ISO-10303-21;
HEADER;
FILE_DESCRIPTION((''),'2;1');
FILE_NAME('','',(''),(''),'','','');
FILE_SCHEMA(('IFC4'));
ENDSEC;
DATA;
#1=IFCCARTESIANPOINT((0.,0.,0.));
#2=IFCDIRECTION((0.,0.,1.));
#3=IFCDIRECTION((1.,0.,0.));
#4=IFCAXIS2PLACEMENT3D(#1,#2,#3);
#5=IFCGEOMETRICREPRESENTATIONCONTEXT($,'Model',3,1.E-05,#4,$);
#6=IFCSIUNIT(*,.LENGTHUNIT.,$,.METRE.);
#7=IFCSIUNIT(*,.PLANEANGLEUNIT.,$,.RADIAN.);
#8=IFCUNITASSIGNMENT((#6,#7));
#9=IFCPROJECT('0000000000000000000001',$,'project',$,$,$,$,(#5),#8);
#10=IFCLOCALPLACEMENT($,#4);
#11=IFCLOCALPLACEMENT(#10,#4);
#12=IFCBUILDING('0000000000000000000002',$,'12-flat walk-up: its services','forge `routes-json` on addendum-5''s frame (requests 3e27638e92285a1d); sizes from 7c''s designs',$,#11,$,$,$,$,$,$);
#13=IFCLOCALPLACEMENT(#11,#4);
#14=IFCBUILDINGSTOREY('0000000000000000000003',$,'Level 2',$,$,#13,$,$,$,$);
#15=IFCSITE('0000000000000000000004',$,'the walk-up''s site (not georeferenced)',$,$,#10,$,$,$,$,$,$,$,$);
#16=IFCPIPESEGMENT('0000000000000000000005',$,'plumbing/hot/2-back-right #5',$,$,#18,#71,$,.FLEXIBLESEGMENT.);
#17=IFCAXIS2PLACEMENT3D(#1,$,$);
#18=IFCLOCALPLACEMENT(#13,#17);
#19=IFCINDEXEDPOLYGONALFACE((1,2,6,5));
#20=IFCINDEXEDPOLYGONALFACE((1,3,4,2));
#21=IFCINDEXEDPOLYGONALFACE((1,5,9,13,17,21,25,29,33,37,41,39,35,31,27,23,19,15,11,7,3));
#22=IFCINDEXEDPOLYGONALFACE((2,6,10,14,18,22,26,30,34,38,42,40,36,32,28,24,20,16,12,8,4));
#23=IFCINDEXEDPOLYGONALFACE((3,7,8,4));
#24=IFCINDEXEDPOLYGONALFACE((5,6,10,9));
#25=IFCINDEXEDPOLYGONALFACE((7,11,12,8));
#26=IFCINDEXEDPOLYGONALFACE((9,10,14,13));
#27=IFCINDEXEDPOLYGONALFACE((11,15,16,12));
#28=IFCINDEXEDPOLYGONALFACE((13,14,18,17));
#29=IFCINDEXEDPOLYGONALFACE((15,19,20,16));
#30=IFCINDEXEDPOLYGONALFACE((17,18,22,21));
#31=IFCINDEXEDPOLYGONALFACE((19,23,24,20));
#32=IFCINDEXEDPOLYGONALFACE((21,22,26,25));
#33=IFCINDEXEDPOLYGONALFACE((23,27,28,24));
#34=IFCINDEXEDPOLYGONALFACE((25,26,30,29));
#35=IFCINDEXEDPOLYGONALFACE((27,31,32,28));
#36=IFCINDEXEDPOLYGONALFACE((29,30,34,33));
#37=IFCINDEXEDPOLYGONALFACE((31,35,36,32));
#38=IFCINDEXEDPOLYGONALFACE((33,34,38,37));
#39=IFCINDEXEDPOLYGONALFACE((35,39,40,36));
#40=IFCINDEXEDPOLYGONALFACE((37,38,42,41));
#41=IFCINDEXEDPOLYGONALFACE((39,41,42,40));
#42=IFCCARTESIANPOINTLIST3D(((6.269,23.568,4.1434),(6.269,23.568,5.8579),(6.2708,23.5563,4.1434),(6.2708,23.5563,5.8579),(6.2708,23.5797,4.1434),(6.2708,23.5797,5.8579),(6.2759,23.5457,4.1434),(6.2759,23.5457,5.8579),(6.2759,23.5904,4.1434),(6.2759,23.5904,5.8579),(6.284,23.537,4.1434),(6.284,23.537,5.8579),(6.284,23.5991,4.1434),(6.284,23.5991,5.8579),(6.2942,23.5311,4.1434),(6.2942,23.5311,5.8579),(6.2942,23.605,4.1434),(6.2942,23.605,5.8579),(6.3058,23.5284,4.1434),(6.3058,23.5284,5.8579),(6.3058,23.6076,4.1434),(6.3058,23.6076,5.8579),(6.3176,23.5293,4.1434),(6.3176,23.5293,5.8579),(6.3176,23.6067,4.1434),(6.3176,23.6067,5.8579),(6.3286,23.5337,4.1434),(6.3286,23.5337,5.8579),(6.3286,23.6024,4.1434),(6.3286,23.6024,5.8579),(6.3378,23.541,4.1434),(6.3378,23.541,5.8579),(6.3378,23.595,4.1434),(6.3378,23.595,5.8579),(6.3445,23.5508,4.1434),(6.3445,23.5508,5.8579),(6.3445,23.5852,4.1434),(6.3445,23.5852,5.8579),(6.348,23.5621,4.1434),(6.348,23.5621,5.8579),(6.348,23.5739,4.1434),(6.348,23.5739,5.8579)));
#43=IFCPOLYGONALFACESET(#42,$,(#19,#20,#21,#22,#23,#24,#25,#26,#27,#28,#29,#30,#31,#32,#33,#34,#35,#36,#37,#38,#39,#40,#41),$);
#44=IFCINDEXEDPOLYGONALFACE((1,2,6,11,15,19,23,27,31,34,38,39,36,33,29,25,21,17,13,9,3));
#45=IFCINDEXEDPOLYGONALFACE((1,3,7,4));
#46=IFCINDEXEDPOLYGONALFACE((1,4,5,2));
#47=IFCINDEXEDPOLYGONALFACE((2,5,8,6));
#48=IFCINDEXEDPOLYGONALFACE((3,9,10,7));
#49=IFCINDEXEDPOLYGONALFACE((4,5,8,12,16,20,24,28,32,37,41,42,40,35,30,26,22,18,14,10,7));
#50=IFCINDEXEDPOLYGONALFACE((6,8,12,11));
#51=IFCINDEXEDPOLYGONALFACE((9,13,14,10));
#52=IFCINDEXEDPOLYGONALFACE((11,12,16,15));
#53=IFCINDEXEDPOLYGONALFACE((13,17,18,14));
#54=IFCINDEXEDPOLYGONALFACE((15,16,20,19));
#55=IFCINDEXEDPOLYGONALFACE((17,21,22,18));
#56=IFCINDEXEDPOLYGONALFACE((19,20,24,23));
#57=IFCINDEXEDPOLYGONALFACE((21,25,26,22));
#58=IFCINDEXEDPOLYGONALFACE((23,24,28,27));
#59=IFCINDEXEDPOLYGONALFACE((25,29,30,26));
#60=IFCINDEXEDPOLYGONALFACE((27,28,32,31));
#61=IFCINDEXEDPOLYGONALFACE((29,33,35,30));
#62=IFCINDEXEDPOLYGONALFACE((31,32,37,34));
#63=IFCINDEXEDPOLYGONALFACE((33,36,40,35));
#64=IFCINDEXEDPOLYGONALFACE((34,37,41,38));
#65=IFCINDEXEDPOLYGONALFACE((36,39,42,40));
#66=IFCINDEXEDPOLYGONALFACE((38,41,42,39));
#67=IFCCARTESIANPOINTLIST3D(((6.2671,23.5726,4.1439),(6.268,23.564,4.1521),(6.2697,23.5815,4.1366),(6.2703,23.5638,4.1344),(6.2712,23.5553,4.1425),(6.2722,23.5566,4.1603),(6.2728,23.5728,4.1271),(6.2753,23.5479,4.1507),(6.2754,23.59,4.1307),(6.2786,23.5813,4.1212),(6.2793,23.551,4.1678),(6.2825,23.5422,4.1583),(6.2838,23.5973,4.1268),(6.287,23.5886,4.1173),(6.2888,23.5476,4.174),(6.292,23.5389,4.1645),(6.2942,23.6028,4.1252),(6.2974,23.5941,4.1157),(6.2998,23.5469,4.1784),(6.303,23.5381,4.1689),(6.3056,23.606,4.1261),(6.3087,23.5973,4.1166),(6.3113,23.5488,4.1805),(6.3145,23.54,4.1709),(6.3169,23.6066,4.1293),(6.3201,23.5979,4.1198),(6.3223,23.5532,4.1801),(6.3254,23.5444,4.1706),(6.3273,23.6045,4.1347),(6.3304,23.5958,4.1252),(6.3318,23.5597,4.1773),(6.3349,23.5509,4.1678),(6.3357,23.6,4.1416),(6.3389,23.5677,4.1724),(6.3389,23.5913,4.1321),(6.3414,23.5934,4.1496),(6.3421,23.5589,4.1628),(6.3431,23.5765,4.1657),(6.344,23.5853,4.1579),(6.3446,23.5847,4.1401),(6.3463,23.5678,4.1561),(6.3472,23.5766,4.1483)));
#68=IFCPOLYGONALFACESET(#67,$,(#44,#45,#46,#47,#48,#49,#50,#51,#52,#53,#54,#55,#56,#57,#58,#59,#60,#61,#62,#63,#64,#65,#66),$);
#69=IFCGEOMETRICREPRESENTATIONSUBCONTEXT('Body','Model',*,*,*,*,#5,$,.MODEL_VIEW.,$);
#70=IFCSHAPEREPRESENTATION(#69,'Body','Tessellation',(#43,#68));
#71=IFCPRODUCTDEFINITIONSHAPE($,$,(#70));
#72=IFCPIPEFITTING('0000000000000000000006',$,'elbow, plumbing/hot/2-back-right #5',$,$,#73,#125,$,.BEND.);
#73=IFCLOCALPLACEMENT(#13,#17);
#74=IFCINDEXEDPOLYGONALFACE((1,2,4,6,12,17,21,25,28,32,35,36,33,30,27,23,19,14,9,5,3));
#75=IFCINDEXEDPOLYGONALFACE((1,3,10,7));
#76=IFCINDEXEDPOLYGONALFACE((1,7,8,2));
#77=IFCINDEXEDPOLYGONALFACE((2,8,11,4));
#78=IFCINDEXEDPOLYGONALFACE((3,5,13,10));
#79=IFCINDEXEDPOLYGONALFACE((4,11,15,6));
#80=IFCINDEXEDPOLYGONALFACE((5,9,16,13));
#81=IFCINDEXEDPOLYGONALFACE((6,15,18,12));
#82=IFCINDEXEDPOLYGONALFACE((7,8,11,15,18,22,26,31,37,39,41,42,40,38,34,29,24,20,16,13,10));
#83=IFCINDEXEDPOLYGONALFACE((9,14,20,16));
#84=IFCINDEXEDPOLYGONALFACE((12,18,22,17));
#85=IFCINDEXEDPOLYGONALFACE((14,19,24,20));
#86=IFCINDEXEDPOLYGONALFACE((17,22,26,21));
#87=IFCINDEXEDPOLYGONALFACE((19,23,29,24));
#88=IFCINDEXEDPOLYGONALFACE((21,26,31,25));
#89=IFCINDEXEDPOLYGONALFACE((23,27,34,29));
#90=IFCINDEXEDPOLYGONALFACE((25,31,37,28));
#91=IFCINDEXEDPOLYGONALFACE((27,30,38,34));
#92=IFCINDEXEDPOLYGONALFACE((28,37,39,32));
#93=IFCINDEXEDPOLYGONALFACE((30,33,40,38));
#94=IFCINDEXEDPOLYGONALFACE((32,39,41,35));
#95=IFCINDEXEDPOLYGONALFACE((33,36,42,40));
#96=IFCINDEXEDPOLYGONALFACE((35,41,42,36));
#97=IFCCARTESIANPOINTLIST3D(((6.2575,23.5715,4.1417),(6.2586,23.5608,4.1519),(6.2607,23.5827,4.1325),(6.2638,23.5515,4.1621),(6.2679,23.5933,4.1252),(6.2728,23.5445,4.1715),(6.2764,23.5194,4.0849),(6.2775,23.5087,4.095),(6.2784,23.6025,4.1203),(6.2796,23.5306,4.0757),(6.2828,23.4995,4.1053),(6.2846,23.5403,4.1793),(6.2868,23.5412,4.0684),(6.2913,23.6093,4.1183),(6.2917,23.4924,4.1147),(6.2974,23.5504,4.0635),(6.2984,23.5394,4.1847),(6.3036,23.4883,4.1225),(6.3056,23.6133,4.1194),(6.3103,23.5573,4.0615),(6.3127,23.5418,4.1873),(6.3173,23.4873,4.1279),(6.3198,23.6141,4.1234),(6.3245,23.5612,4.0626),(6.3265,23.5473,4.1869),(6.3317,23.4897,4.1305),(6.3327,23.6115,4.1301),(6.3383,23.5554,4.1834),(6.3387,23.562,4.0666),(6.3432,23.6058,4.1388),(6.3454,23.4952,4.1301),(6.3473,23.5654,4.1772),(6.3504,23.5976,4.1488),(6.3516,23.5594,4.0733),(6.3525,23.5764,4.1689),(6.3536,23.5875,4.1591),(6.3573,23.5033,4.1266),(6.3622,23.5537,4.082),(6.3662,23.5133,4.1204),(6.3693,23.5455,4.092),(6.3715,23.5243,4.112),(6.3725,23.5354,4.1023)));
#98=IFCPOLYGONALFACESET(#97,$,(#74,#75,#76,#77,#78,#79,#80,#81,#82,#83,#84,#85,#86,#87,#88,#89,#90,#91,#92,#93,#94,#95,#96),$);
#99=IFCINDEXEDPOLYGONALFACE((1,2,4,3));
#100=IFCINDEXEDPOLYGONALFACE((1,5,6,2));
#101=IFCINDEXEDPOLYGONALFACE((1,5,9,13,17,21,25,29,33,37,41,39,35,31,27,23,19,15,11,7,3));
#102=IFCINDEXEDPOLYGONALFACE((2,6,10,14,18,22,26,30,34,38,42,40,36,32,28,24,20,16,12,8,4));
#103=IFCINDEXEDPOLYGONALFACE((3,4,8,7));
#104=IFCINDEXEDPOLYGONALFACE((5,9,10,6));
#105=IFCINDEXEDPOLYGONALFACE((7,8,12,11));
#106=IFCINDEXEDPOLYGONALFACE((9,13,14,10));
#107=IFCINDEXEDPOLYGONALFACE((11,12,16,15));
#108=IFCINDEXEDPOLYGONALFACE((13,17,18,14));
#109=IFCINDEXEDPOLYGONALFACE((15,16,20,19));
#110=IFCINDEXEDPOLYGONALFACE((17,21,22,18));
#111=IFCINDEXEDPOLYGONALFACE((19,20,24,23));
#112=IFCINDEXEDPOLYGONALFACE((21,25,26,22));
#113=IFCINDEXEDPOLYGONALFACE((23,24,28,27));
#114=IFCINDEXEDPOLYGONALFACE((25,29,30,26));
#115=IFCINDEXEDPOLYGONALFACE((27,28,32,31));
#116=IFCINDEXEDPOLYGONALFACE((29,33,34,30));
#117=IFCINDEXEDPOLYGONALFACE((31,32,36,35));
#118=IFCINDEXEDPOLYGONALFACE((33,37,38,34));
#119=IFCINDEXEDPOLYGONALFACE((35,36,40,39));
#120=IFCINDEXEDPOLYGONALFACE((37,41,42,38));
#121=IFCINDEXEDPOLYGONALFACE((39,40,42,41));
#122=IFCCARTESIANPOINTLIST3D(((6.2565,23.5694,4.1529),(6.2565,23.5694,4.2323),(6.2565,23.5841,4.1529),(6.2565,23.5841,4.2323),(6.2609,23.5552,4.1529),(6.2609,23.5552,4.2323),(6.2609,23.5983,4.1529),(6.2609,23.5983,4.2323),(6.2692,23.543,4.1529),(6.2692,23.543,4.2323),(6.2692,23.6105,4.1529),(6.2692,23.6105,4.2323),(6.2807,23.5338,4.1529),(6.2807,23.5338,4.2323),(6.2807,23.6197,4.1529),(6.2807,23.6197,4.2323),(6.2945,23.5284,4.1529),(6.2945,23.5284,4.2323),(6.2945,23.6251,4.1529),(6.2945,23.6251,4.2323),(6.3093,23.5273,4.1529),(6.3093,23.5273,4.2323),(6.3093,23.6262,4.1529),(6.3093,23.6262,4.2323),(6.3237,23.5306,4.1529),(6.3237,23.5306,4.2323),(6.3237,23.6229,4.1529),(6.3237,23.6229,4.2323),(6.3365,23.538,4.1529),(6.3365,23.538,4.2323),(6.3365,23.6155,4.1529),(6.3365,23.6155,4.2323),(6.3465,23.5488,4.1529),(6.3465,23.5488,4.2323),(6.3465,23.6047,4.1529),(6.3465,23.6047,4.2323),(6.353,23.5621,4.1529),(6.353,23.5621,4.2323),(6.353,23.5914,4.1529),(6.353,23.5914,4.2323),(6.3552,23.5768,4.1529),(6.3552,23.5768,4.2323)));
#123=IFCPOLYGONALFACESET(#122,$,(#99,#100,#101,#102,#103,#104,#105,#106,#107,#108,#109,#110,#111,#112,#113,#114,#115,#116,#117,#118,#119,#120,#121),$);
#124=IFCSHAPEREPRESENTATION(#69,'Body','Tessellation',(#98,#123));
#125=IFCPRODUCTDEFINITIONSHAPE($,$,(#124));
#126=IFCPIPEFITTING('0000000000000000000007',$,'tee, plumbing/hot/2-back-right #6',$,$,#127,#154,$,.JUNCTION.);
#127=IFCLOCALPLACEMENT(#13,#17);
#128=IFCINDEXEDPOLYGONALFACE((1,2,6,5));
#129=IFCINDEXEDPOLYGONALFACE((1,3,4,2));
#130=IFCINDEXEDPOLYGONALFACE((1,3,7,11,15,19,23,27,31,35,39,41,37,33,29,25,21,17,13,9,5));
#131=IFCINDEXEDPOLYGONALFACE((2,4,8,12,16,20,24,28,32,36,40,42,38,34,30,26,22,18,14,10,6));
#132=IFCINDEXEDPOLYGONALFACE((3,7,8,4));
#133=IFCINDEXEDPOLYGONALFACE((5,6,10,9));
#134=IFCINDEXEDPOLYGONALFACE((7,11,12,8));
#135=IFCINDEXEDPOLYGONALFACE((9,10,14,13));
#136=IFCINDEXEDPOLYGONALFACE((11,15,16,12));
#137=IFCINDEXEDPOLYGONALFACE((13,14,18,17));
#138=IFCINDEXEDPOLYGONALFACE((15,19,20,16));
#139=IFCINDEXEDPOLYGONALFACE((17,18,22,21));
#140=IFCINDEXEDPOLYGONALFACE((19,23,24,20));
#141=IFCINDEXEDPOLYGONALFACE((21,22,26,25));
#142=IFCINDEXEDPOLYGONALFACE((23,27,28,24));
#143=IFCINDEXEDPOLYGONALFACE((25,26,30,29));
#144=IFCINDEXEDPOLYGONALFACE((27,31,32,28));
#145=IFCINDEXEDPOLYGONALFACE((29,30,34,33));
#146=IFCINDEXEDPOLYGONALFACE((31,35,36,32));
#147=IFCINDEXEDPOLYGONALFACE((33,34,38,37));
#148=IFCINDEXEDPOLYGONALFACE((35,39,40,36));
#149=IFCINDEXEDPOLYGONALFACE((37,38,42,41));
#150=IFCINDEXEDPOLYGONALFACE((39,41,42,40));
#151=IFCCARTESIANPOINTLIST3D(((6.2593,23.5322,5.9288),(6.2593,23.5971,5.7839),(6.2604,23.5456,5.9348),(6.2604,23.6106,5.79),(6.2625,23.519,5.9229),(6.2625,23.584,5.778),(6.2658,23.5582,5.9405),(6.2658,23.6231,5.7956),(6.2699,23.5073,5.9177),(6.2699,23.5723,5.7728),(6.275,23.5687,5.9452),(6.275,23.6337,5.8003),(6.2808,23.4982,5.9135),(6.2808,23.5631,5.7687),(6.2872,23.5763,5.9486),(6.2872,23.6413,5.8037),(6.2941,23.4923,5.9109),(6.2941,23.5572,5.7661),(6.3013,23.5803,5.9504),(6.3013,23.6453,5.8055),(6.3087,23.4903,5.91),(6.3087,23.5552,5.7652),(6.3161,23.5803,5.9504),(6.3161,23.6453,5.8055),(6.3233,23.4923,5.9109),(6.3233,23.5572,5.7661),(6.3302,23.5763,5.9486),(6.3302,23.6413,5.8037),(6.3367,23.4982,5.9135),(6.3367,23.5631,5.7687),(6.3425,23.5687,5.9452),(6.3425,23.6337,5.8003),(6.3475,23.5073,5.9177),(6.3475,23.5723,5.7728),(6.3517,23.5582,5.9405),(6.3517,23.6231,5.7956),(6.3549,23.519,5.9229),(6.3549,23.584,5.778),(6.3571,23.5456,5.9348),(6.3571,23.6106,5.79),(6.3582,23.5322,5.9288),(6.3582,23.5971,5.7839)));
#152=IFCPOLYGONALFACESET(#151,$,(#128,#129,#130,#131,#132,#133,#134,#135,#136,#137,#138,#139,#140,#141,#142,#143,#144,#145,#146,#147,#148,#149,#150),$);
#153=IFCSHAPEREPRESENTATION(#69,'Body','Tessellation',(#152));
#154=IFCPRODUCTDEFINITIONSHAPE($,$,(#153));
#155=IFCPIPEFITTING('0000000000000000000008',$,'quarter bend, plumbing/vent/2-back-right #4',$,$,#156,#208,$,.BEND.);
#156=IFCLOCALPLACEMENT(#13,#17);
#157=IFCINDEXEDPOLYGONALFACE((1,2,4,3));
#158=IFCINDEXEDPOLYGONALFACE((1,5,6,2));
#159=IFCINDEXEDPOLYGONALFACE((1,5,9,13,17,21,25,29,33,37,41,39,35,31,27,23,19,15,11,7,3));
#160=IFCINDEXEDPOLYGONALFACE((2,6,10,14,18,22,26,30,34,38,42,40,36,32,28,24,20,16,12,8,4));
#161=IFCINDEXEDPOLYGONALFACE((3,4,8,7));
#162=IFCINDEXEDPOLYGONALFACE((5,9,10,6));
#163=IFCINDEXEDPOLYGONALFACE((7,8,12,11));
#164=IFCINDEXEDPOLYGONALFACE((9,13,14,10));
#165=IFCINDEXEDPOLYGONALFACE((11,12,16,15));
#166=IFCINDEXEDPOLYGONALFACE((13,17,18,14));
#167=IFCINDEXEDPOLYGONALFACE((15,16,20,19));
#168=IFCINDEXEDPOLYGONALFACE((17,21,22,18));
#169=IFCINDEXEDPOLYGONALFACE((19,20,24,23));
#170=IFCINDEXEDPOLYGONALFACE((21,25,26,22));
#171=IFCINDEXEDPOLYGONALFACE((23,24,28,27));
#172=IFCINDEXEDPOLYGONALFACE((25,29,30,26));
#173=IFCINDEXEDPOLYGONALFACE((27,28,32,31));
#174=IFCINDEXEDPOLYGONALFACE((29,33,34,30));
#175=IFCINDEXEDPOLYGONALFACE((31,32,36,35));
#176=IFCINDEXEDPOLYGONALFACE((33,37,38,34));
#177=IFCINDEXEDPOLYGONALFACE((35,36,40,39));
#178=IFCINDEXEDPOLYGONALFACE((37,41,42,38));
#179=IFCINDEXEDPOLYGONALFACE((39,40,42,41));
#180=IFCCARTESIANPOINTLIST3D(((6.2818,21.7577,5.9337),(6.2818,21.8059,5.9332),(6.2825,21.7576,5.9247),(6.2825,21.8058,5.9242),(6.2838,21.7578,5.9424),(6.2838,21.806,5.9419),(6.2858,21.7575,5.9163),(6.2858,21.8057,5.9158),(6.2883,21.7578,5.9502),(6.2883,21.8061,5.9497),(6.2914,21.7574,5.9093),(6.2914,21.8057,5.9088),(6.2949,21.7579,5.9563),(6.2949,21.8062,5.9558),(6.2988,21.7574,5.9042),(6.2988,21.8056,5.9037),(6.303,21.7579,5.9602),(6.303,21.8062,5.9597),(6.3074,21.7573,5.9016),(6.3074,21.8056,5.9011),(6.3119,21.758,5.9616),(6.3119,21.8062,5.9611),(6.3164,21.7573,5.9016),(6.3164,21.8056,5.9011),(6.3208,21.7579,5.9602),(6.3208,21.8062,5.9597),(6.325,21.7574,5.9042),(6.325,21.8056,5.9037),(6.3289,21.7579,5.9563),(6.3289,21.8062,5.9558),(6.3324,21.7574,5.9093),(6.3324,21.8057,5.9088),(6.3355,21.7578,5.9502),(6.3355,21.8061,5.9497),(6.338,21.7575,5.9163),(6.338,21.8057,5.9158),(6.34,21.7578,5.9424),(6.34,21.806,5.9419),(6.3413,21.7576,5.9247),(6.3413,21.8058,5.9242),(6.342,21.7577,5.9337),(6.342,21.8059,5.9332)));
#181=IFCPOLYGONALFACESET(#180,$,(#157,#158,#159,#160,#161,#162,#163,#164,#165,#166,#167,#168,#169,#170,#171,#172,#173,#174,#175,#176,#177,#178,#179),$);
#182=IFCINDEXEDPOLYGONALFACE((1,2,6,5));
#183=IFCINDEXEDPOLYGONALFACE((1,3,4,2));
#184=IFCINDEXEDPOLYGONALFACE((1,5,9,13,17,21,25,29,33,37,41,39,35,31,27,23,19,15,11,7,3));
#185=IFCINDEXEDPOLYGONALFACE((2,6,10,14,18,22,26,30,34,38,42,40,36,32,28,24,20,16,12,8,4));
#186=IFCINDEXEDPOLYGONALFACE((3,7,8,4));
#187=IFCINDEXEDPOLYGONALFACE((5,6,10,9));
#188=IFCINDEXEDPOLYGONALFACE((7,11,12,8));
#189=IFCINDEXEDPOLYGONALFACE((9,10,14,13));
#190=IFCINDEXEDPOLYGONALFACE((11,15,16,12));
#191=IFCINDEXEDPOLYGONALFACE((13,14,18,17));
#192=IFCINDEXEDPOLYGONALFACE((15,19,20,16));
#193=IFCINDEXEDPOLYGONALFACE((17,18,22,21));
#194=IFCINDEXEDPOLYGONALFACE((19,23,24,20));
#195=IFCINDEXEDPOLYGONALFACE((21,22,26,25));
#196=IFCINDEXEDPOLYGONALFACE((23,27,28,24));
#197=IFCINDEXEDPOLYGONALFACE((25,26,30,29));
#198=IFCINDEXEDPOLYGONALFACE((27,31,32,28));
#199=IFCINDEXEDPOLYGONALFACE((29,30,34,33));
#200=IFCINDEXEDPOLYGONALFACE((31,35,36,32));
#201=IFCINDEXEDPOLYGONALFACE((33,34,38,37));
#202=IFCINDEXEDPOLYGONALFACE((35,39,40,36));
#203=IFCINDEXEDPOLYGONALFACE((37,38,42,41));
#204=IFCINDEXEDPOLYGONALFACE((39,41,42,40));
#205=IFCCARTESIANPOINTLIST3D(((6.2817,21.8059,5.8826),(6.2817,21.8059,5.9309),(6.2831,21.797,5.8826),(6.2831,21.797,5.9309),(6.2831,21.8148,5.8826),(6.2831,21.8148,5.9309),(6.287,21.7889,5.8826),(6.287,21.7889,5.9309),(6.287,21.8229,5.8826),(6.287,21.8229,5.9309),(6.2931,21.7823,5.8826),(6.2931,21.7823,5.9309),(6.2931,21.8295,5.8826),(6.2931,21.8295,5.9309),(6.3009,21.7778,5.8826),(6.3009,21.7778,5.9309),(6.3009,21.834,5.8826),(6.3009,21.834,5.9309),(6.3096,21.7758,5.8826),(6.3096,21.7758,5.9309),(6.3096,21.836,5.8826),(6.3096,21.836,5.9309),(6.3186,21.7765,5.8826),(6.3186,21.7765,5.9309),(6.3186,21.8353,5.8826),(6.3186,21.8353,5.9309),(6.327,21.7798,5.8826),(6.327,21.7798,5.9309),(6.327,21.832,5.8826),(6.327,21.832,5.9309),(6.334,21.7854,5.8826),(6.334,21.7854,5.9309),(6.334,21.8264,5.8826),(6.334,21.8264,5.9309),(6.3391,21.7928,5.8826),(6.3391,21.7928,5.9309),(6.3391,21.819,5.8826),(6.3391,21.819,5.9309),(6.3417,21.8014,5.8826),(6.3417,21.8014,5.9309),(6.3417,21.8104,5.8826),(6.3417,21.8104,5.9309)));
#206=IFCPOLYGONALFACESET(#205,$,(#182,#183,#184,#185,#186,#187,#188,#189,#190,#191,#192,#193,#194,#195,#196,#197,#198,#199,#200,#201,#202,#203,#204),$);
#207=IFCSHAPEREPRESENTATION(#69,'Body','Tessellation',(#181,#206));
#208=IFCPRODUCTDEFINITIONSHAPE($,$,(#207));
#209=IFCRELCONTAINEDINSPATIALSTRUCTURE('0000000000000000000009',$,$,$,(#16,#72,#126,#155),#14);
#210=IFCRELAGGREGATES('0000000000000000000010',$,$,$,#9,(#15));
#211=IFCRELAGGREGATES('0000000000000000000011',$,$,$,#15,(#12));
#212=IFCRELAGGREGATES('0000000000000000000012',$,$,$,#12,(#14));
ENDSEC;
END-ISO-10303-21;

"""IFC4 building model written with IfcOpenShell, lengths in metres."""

from ifc_helpers import new_model, entity, si_unit, frame, origin_with_axes, place, context, subcontext, project, spatial, element, save


model = new_model("IFC4")

# Units and contexts
model_context = context("Model", 3, precision=1e-05, world=origin_with_axes())
body_context = subcontext(model_context, "Body", "Model", "MODEL_VIEW")
ifc_project = project(units=[si_unit("LENGTHUNIT", "METRE"), si_unit("PLANEANGLEUNIT", "RADIAN")], contexts=[model_context])

# Site, building, storey
site_placement = place(None, origin_with_axes())
site = spatial("IfcSite", under=ifc_project, at=site_placement, Name="the walk-up's site (not georeferenced)")
building_placement = place(site_placement, origin_with_axes())
building = spatial("IfcBuilding", under=site, at=building_placement, Name="12-flat walk-up: its services", Description="forge `routes-json` on addendum-5's frame (requests 3e27638e92285a1d); sizes from 7c's designs")
storey_placement = place(building_placement, origin_with_axes())
storey = spatial("IfcBuildingStorey", under=building, at=storey_placement, Name="Level 2")

# Pipe segment
pipe_segment_1_placement = place(storey_placement, frame((6.3087, 23.568, 5.8579), z_axis=(0.0, 0.0, 1.0), x_axis=(1.0, 0.0, 0.0)))
element("IfcPipeSegment", 1, at=pipe_segment_1_placement, inside=storey, Name="plumbing/hot/2-back-right #5", PredefinedType="FLEXIBLESEGMENT", context=body_context, shape_type="AdvancedSweptSolid", body=[
    entity("IfcSweptDiskSolid", entity("IfcPolyline", [entity("IfcCartesianPoint", [0.0, 0.0, 0.0]), entity("IfcCartesianPoint", [0.0, 0.0, -1.7145])]), 0.0397),
    entity("IfcSweptDiskSolid", entity("IfcPolyline", [entity("IfcCartesianPoint", [0.0, 0.0, -1.7145]), entity("IfcCartesianPoint", [-0.0032, 0.0087, -1.705])]), 0.0397),
])

# Pipe fitting
pipe_fitting_1_placement = place(storey_placement, frame((6.3245, 23.5247, 4.0961), z_axis=(0.0, 0.0, 1.0), x_axis=(1.0, 0.0, 0.0)))
element("IfcPipeFitting", 2, at=pipe_fitting_1_placement, inside=storey, Name="elbow, plumbing/hot/2-back-right #5", PredefinedType="BEND", context=body_context, shape_type="AdvancedSweptSolid", body=[
    entity("IfcSweptDiskSolid", entity("IfcPolyline", [entity("IfcCartesianPoint", [0.0, 0.0, 0.0]), entity("IfcCartesianPoint", [-0.0189, 0.0521, 0.0568])]), 0.0496),
    entity("IfcSweptDiskSolid", entity("IfcPolyline", [entity("IfcCartesianPoint", [-0.0189, 0.0521, 0.0568]), entity("IfcCartesianPoint", [-0.0189, 0.0521, 0.1362])]), 0.0496),
])

# Pipe fittings
pipe_fitting_2_placement = place(storey_placement, frame((6.3087, 23.5356, 5.9303), z_axis=(0.0, 0.0, 1.0), x_axis=(1.0, 0.0, 0.0)))
element("IfcPipeFitting", 3, at=pipe_fitting_2_placement, inside=storey, Name="tee, plumbing/hot/2-back-right #6", PredefinedType="JUNCTION", context=body_context, shape_type="AdvancedSweptSolid", body=[
    entity("IfcSweptDiskSolid", entity("IfcPolyline", [entity("IfcCartesianPoint", [0.0, 0.0, 0.0]), entity("IfcCartesianPoint", [0.0, 0.0649, -0.1449])]), 0.0496),
])
pipe_fitting_3_placement = place(storey_placement, frame((6.3119, 21.7576, 5.9314), z_axis=(0.0, 0.0, 1.0), x_axis=(1.0, 0.0, 0.0)))
element("IfcPipeFitting", 4, at=pipe_fitting_3_placement, inside=storey, Name="quarter bend, plumbing/vent/2-back-right #4", PredefinedType="BEND", context=body_context, shape_type="AdvancedSweptSolid", body=[
    entity("IfcSweptDiskSolid", entity("IfcPolyline", [entity("IfcCartesianPoint", [0.0, 0.0, 0.0]), entity("IfcCartesianPoint", [0.0, 0.0483, -0.0005])]), 0.0302),
    entity("IfcSweptDiskSolid", entity("IfcPolyline", [entity("IfcCartesianPoint", [0.0, 0.0483, -0.0005]), entity("IfcCartesianPoint", [0.0, 0.0483, -0.0488])]), 0.0302),
])

save(model, "model.ifc")
